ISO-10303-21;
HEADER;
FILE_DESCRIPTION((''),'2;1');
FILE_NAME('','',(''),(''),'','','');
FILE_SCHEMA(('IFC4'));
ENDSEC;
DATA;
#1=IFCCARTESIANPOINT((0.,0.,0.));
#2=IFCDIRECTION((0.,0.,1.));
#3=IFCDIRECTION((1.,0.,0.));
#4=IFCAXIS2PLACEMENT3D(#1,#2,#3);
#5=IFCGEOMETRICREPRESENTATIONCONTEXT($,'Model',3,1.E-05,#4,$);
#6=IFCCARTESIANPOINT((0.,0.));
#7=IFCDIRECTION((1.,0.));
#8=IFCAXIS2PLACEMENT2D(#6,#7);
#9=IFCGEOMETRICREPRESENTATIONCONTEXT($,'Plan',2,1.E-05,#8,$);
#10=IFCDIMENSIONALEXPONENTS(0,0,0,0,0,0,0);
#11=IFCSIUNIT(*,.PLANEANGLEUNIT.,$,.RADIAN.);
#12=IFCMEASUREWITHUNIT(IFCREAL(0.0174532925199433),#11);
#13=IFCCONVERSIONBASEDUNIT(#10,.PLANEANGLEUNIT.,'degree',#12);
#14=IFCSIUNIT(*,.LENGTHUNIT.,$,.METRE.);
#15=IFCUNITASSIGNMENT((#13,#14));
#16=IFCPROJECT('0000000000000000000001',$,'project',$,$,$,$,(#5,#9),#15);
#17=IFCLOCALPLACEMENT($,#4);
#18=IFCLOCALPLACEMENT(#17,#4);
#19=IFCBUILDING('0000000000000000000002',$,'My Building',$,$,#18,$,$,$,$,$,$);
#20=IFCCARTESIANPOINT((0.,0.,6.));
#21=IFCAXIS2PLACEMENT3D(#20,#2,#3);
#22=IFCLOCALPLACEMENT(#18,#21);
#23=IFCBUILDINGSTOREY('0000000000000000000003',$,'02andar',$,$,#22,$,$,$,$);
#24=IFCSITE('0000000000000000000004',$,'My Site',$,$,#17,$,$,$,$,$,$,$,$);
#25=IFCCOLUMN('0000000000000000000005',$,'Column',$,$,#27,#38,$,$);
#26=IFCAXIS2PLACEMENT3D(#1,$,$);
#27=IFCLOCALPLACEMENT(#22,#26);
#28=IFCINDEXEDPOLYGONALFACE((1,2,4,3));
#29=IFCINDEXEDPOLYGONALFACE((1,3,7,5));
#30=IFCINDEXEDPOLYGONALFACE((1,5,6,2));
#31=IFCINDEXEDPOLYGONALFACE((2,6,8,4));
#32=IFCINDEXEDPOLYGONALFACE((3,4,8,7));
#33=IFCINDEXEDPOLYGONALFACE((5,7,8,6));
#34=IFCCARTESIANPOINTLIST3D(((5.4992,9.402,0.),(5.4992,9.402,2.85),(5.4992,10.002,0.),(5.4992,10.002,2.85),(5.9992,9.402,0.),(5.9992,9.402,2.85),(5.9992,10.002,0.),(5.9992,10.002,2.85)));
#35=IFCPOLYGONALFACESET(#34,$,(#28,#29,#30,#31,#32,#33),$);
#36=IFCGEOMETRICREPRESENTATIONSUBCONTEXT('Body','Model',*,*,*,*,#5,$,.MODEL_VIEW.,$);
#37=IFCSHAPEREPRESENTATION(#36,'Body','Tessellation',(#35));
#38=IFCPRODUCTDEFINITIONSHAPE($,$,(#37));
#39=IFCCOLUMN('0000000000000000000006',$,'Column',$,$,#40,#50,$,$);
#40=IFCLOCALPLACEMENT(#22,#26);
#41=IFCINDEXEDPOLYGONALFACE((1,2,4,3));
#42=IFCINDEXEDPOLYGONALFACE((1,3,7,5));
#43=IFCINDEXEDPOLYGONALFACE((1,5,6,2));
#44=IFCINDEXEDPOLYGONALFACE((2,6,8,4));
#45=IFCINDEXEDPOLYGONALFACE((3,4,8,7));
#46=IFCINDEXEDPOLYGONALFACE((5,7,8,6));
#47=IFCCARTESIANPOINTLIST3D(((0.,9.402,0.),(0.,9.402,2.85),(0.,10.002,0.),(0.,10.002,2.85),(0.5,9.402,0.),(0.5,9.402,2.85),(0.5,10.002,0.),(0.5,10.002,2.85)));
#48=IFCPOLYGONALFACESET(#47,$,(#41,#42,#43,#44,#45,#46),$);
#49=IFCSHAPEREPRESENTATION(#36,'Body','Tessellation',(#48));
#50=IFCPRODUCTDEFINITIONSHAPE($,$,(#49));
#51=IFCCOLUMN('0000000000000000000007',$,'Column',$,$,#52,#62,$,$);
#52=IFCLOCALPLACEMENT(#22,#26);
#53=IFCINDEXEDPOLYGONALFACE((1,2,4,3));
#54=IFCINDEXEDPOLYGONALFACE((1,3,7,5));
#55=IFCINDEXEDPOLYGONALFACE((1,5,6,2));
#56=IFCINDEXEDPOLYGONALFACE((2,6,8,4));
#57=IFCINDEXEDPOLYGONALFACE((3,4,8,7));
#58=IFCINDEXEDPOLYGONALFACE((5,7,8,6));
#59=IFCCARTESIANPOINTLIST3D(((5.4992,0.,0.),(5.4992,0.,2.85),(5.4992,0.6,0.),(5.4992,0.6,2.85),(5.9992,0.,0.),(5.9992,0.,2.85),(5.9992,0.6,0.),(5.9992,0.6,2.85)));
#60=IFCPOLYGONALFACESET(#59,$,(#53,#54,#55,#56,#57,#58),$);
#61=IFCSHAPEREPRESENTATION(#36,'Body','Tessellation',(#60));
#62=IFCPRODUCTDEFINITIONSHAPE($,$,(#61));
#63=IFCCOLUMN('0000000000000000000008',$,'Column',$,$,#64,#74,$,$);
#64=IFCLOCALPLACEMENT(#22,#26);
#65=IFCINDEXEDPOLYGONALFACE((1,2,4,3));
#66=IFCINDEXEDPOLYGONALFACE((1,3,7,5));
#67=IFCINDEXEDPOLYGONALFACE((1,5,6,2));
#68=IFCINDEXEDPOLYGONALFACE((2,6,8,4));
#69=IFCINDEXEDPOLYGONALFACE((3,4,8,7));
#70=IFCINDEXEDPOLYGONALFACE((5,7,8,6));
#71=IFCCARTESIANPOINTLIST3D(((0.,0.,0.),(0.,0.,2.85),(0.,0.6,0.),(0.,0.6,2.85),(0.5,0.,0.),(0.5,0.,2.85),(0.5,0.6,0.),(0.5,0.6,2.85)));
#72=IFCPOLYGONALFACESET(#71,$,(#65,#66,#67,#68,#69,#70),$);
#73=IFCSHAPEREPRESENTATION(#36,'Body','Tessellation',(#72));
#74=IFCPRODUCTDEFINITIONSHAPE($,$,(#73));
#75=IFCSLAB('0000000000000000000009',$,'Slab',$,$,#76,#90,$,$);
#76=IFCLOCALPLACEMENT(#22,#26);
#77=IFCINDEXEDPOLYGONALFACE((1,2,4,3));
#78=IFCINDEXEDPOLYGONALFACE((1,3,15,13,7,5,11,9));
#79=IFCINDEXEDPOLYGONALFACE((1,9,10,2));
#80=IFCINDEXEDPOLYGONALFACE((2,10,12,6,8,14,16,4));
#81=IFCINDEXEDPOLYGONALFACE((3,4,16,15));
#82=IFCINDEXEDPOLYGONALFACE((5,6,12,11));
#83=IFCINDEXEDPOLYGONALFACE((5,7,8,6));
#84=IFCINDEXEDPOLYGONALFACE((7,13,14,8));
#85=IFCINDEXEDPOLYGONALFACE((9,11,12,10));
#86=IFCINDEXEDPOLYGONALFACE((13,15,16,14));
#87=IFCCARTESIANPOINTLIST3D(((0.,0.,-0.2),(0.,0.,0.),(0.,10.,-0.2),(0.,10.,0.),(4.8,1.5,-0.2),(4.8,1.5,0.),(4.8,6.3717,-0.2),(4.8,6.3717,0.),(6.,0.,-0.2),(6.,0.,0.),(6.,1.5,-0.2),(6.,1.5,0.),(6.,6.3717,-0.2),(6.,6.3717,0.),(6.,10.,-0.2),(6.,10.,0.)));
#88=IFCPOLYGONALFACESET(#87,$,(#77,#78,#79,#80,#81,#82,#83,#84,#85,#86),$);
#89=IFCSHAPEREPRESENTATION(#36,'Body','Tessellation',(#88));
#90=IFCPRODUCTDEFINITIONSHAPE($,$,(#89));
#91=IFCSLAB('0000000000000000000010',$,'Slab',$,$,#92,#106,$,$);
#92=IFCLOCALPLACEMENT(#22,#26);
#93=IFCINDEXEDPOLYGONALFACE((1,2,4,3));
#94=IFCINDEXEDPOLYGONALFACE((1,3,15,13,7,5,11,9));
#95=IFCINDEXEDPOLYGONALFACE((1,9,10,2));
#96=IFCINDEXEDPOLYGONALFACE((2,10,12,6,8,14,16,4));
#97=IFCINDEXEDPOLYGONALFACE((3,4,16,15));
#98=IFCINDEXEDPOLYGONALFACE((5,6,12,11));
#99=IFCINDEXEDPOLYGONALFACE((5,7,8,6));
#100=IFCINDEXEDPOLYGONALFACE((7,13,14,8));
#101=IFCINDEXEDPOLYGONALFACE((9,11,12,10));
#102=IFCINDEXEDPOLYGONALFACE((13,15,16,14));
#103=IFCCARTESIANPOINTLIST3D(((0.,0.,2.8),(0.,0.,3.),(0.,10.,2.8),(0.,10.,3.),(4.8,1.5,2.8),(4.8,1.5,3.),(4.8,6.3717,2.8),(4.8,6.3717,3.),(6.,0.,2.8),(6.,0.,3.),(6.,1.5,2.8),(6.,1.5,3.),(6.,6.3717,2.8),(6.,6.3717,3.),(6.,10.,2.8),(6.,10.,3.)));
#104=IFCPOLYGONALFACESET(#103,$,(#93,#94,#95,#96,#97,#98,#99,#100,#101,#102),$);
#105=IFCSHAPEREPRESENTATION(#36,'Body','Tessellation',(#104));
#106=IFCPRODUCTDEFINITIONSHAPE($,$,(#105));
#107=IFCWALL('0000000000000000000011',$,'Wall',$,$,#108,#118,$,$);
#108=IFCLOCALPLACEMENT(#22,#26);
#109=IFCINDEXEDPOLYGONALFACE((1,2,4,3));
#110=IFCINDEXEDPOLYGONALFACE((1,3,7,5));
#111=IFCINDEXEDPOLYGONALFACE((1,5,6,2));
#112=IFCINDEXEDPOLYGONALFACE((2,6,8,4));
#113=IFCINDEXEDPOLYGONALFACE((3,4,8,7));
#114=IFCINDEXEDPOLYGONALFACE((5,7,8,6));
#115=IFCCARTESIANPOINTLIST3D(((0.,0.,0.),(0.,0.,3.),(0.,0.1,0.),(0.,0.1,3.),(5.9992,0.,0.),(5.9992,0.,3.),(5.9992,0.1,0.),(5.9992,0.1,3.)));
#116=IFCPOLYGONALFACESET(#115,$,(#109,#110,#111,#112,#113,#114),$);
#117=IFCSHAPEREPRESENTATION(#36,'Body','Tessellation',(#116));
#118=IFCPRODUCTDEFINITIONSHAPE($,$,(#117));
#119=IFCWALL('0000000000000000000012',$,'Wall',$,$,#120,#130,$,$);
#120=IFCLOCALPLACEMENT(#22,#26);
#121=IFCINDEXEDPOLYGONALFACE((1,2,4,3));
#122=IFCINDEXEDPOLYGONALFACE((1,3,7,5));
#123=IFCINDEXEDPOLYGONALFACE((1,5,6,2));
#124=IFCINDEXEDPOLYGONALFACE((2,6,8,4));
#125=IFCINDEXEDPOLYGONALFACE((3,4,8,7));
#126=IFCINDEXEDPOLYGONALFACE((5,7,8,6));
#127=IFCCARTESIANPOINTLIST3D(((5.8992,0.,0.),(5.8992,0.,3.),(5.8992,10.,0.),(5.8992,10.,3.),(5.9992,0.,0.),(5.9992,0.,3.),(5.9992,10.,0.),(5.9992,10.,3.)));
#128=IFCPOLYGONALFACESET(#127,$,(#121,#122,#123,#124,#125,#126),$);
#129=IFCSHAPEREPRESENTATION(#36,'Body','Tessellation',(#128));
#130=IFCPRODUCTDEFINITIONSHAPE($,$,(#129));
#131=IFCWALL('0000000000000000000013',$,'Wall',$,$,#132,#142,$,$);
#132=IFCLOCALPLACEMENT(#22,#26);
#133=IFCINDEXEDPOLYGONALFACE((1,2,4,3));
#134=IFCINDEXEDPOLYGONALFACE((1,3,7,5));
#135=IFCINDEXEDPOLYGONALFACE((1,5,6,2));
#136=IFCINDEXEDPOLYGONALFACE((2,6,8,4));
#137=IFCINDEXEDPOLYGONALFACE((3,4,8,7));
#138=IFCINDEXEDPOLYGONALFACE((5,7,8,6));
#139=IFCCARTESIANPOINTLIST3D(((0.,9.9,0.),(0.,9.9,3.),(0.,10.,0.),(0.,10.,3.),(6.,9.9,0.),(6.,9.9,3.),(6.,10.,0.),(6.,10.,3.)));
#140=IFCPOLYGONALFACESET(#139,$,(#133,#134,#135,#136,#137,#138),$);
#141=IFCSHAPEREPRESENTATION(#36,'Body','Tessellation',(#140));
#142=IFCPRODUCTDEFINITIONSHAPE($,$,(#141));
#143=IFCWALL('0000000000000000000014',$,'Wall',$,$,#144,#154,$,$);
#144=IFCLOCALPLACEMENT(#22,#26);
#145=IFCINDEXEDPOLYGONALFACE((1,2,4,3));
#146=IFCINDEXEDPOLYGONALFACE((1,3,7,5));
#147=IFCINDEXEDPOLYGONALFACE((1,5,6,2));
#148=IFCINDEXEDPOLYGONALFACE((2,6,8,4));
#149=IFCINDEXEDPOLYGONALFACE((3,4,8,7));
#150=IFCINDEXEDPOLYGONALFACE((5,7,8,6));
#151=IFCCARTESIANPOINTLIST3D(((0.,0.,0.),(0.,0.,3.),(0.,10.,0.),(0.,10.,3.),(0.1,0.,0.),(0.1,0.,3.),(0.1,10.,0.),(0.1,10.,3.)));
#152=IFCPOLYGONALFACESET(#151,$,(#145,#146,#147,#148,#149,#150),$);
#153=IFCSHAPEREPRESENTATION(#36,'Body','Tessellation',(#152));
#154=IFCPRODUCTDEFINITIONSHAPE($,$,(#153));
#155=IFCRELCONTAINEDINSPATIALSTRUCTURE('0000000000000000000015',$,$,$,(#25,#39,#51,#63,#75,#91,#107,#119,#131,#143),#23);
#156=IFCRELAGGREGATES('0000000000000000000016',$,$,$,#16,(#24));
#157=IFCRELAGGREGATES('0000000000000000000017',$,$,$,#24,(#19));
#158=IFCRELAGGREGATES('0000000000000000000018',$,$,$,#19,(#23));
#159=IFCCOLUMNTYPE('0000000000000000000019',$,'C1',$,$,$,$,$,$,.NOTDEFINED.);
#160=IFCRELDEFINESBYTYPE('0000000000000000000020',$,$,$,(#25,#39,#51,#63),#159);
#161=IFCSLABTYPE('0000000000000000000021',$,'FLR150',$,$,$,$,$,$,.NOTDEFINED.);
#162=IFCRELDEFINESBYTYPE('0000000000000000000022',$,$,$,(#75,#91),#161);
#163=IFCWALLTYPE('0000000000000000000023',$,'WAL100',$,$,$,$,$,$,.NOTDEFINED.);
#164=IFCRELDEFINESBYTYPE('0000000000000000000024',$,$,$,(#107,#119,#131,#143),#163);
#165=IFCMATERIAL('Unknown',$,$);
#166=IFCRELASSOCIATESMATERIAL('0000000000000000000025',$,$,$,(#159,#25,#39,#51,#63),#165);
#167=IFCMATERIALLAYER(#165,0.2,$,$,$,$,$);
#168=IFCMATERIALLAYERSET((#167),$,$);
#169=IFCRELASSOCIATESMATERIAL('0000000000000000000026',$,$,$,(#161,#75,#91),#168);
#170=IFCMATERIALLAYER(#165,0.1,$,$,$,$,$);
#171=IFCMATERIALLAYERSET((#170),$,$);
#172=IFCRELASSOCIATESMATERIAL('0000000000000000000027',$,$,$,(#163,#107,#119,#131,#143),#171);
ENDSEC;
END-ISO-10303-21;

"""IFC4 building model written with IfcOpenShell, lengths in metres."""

from ifc_helpers import new_model, entity, si_unit, converted_unit, frame, origin_with_axes, origin_2d_with_axis, place, context, subcontext, project, spatial, line, indexed_curve, rectangle, outline, extrude, material, layer, layer_set, layer_usage, material_profile, profile_set, profile_usage, type_object, element, save


model = new_model("IFC4")

# Units and contexts
model_context = context("Model", 3, precision=1e-05, world=origin_with_axes())
plan_context = context("Plan", 2, precision=1e-05, world=origin_2d_with_axis())
body_context = subcontext(model_context, "Body", "Model", "MODEL_VIEW")
ifc_project = project(units=[converted_unit("PLANEANGLEUNIT", "degree", entity("IfcReal", 0.0174532925199433), si_unit("PLANEANGLEUNIT", "RADIAN"), dimensions=[0, 0, 0, 0, 0, 0, 0]), si_unit("LENGTHUNIT", "METRE")], contexts=[model_context, plan_context])

# Site, building, storey
site_placement = place(None, origin_with_axes())
site = spatial("IfcSite", under=ifc_project, at=site_placement, Name="My Site")
building_placement = place(site_placement, origin_with_axes())
building = spatial("IfcBuilding", under=site, at=building_placement, Name="My Building")
storey_placement = place(building_placement, frame((0.0, 0.0, 6.0), z_axis=(0.0, 0.0, 1.0), x_axis=(1.0, 0.0, 0.0)))
storey = spatial("IfcBuildingStorey", under=building, at=storey_placement, Name="02andar")

# Columns
ifc_material = material(Name="Unknown")
ifc_material_profile = material_profile(ifc_material, rectangle(XDim=0.5, YDim=0.6))
ifc_profile_set = profile_set([ifc_material_profile])
ifc_profile_usage_1 = profile_usage(ifc_profile_set, cardinal=5)
column_type = type_object("IfcColumnType", Name="C1", PredefinedType="NOTDEFINED", material=ifc_profile_set)
column_1_placement = place(storey_placement, frame((5.7492, 9.702, 0.0), z_axis=(0.0, 0.0, 1.0), x_axis=(1.0, 0.0, 0.0)))
element("IfcColumn", 1, at=column_1_placement, inside=storey, type_object=column_type, material=ifc_profile_usage_1, Name="Column", context=body_context, shape_type="SweptSolid", body=[
    extrude(rectangle(XDim=0.5, YDim=0.6), origin_with_axes(), (0.0, 0.0, 1.0), 2.85),
])
ifc_profile_usage_2 = profile_usage(ifc_profile_set, cardinal=5)
column_2_placement = place(storey_placement, frame((0.25, 9.702, 0.0), z_axis=(0.0, 0.0, 1.0), x_axis=(1.0, 0.0, 0.0)))
element("IfcColumn", 2, at=column_2_placement, inside=storey, type_object=column_type, material=ifc_profile_usage_2, Name="Column", context=body_context, shape_type="SweptSolid", body=[
    extrude(rectangle(XDim=0.5, YDim=0.6), origin_with_axes(), (0.0, 0.0, 1.0), 2.85),
])
ifc_profile_usage_3 = profile_usage(ifc_profile_set, cardinal=5)
column_3_placement = place(storey_placement, frame((5.7492, 0.3, 0.0), z_axis=(0.0, 0.0, 1.0), x_axis=(1.0, 0.0, 0.0)))
element("IfcColumn", 3, at=column_3_placement, inside=storey, type_object=column_type, material=ifc_profile_usage_3, Name="Column", context=body_context, shape_type="SweptSolid", body=[
    extrude(rectangle(XDim=0.5, YDim=0.6), origin_with_axes(), (0.0, 0.0, 1.0), 2.85),
])
ifc_profile_usage_4 = profile_usage(ifc_profile_set, cardinal=5)
column_4_placement = place(storey_placement, frame((0.25, 0.3, 0.0), z_axis=(0.0, 0.0, 1.0), x_axis=(1.0, 0.0, 0.0)))
element("IfcColumn", 4, at=column_4_placement, inside=storey, type_object=column_type, material=ifc_profile_usage_4, Name="Column", context=body_context, shape_type="SweptSolid", body=[
    extrude(rectangle(XDim=0.5, YDim=0.6), origin_with_axes(), (0.0, 0.0, 1.0), 2.85),
])

# Slabs
ifc_layer_1 = layer(ifc_material, 0.2)
ifc_layer_set_1 = layer_set([ifc_layer_1])
ifc_layer_usage_1 = layer_usage(ifc_layer_set_1, "AXIS3", "POSITIVE", 0.0)
slab_type = type_object("IfcSlabType", Name="FLR150", PredefinedType="NOTDEFINED", material=ifc_layer_set_1)
slab_1_placement = place(storey_placement, frame((0.0, 0.0, -0.2), z_axis=(0.0, 0.0, 1.0), x_axis=(1.0, 0.0, 0.0)))
element("IfcSlab", 5, at=slab_1_placement, inside=storey, type_object=slab_type, material=ifc_layer_usage_1, Name="Slab", context=body_context, shape_type="SweptSolid", body=[
    extrude(outline(indexed_curve([(6.0, 1.5), (4.8, 1.5), (4.8, 6.3717), (6.0, 6.3717), (6.0, 10.0), (0.0, 10.0), (0.0, 0.0), (6.0, 0.0)], segments=[line(5, 6), line(6, 7), line(7, 8), line(8, 1), line(1, 2), line(2, 3), line(3, 4), line(4, 5)], self_intersect=False)), None, (0.0, 0.0, 1.0), 0.2),
])
ifc_layer_usage_2 = layer_usage(ifc_layer_set_1, "AXIS3", "POSITIVE", 0.0)
slab_2_placement = place(storey_placement, frame((0.0, 0.0, 2.8), z_axis=(0.0, 0.0, 1.0), x_axis=(1.0, 0.0, 0.0)))
element("IfcSlab", 6, at=slab_2_placement, inside=storey, type_object=slab_type, material=ifc_layer_usage_2, Name="Slab", context=body_context, shape_type="SweptSolid", body=[
    extrude(outline(indexed_curve([(6.0, 1.5), (4.8, 1.5), (4.8, 6.3717), (6.0, 6.3717), (6.0, 10.0), (0.0, 10.0), (0.0, 0.0), (6.0, 0.0)], segments=[line(5, 6), line(6, 7), line(7, 8), line(8, 1), line(1, 2), line(2, 3), line(3, 4), line(4, 5)], self_intersect=False)), None, (0.0, 0.0, 1.0), 0.2),
])

# Walls
ifc_layer_2 = layer(ifc_material, 0.1)
ifc_layer_set_2 = layer_set([ifc_layer_2])
ifc_layer_usage_3 = layer_usage(ifc_layer_set_2, "AXIS2", "POSITIVE", 0.0)
wall_type = type_object("IfcWallType", Name="WAL100", PredefinedType="NOTDEFINED", material=ifc_layer_set_2)
wall_1_placement = place(storey_placement, origin_with_axes())
element("IfcWall", 7, at=wall_1_placement, inside=storey, type_object=wall_type, material=ifc_layer_usage_3, Name="Wall", context=body_context, shape_type="SweptSolid", body=[
    extrude(outline(indexed_curve([(0.0, 0.0), (0.0, 0.1), (5.9992, 0.1), (5.9992, 0.0), (0.0, 0.0)], self_intersect=False)), origin_with_axes(), (0.0, 0.0, 1.0), 3.0),
])
ifc_layer_usage_4 = layer_usage(ifc_layer_set_2, "AXIS2", "POSITIVE", 0.0)
wall_2_placement = place(storey_placement, frame((5.9992, 0.0, 0.0), z_axis=(0.0, 0.0, 1.0), x_axis=(0.0, 1.0, 0.0)))
element("IfcWall", 8, at=wall_2_placement, inside=storey, type_object=wall_type, material=ifc_layer_usage_4, Name="Wall", context=body_context, shape_type="SweptSolid", body=[
    extrude(outline(indexed_curve([(0.0, 0.0), (0.0, 0.1), (10.0, 0.1), (10.0, 0.0), (0.0, 0.0)], self_intersect=False)), origin_with_axes(), (0.0, 0.0, 1.0), 3.0),
])
ifc_layer_usage_5 = layer_usage(ifc_layer_set_2, "AXIS2", "POSITIVE", 0.0)
wall_3_placement = place(storey_placement, frame((6.0, 10.0, 0.0), z_axis=(0.0, 0.0, 1.0), x_axis=(-1.0, 0.000001, 0.0)))
element("IfcWall", 9, at=wall_3_placement, inside=storey, type_object=wall_type, material=ifc_layer_usage_5, Name="Wall", context=body_context, shape_type="SweptSolid", body=[
    extrude(outline(indexed_curve([(0.0, 0.0), (0.0, 0.1), (6.0, 0.1), (6.0, 0.0), (0.0, 0.0)], self_intersect=False)), origin_with_axes(), (0.0, 0.0, 1.0), 3.0),
])
ifc_layer_usage_6 = layer_usage(ifc_layer_set_2, "AXIS2", "POSITIVE", 0.0)
wall_4_placement = place(storey_placement, frame((0.0, 10.0, 0.0), z_axis=(0.0, 0.0, 1.0), x_axis=(-0.000001, -1.0, 0.0)))
element("IfcWall", 10, at=wall_4_placement, inside=storey, type_object=wall_type, material=ifc_layer_usage_6, Name="Wall", context=body_context, shape_type="SweptSolid", body=[
    extrude(outline(indexed_curve([(0.0, 0.0), (0.0, 0.1), (10.0, 0.1), (10.0, 0.0), (0.0, 0.0)], self_intersect=False)), origin_with_axes(), (0.0, 0.0, 1.0), 3.0),
])

save(model, "model.ifc")
